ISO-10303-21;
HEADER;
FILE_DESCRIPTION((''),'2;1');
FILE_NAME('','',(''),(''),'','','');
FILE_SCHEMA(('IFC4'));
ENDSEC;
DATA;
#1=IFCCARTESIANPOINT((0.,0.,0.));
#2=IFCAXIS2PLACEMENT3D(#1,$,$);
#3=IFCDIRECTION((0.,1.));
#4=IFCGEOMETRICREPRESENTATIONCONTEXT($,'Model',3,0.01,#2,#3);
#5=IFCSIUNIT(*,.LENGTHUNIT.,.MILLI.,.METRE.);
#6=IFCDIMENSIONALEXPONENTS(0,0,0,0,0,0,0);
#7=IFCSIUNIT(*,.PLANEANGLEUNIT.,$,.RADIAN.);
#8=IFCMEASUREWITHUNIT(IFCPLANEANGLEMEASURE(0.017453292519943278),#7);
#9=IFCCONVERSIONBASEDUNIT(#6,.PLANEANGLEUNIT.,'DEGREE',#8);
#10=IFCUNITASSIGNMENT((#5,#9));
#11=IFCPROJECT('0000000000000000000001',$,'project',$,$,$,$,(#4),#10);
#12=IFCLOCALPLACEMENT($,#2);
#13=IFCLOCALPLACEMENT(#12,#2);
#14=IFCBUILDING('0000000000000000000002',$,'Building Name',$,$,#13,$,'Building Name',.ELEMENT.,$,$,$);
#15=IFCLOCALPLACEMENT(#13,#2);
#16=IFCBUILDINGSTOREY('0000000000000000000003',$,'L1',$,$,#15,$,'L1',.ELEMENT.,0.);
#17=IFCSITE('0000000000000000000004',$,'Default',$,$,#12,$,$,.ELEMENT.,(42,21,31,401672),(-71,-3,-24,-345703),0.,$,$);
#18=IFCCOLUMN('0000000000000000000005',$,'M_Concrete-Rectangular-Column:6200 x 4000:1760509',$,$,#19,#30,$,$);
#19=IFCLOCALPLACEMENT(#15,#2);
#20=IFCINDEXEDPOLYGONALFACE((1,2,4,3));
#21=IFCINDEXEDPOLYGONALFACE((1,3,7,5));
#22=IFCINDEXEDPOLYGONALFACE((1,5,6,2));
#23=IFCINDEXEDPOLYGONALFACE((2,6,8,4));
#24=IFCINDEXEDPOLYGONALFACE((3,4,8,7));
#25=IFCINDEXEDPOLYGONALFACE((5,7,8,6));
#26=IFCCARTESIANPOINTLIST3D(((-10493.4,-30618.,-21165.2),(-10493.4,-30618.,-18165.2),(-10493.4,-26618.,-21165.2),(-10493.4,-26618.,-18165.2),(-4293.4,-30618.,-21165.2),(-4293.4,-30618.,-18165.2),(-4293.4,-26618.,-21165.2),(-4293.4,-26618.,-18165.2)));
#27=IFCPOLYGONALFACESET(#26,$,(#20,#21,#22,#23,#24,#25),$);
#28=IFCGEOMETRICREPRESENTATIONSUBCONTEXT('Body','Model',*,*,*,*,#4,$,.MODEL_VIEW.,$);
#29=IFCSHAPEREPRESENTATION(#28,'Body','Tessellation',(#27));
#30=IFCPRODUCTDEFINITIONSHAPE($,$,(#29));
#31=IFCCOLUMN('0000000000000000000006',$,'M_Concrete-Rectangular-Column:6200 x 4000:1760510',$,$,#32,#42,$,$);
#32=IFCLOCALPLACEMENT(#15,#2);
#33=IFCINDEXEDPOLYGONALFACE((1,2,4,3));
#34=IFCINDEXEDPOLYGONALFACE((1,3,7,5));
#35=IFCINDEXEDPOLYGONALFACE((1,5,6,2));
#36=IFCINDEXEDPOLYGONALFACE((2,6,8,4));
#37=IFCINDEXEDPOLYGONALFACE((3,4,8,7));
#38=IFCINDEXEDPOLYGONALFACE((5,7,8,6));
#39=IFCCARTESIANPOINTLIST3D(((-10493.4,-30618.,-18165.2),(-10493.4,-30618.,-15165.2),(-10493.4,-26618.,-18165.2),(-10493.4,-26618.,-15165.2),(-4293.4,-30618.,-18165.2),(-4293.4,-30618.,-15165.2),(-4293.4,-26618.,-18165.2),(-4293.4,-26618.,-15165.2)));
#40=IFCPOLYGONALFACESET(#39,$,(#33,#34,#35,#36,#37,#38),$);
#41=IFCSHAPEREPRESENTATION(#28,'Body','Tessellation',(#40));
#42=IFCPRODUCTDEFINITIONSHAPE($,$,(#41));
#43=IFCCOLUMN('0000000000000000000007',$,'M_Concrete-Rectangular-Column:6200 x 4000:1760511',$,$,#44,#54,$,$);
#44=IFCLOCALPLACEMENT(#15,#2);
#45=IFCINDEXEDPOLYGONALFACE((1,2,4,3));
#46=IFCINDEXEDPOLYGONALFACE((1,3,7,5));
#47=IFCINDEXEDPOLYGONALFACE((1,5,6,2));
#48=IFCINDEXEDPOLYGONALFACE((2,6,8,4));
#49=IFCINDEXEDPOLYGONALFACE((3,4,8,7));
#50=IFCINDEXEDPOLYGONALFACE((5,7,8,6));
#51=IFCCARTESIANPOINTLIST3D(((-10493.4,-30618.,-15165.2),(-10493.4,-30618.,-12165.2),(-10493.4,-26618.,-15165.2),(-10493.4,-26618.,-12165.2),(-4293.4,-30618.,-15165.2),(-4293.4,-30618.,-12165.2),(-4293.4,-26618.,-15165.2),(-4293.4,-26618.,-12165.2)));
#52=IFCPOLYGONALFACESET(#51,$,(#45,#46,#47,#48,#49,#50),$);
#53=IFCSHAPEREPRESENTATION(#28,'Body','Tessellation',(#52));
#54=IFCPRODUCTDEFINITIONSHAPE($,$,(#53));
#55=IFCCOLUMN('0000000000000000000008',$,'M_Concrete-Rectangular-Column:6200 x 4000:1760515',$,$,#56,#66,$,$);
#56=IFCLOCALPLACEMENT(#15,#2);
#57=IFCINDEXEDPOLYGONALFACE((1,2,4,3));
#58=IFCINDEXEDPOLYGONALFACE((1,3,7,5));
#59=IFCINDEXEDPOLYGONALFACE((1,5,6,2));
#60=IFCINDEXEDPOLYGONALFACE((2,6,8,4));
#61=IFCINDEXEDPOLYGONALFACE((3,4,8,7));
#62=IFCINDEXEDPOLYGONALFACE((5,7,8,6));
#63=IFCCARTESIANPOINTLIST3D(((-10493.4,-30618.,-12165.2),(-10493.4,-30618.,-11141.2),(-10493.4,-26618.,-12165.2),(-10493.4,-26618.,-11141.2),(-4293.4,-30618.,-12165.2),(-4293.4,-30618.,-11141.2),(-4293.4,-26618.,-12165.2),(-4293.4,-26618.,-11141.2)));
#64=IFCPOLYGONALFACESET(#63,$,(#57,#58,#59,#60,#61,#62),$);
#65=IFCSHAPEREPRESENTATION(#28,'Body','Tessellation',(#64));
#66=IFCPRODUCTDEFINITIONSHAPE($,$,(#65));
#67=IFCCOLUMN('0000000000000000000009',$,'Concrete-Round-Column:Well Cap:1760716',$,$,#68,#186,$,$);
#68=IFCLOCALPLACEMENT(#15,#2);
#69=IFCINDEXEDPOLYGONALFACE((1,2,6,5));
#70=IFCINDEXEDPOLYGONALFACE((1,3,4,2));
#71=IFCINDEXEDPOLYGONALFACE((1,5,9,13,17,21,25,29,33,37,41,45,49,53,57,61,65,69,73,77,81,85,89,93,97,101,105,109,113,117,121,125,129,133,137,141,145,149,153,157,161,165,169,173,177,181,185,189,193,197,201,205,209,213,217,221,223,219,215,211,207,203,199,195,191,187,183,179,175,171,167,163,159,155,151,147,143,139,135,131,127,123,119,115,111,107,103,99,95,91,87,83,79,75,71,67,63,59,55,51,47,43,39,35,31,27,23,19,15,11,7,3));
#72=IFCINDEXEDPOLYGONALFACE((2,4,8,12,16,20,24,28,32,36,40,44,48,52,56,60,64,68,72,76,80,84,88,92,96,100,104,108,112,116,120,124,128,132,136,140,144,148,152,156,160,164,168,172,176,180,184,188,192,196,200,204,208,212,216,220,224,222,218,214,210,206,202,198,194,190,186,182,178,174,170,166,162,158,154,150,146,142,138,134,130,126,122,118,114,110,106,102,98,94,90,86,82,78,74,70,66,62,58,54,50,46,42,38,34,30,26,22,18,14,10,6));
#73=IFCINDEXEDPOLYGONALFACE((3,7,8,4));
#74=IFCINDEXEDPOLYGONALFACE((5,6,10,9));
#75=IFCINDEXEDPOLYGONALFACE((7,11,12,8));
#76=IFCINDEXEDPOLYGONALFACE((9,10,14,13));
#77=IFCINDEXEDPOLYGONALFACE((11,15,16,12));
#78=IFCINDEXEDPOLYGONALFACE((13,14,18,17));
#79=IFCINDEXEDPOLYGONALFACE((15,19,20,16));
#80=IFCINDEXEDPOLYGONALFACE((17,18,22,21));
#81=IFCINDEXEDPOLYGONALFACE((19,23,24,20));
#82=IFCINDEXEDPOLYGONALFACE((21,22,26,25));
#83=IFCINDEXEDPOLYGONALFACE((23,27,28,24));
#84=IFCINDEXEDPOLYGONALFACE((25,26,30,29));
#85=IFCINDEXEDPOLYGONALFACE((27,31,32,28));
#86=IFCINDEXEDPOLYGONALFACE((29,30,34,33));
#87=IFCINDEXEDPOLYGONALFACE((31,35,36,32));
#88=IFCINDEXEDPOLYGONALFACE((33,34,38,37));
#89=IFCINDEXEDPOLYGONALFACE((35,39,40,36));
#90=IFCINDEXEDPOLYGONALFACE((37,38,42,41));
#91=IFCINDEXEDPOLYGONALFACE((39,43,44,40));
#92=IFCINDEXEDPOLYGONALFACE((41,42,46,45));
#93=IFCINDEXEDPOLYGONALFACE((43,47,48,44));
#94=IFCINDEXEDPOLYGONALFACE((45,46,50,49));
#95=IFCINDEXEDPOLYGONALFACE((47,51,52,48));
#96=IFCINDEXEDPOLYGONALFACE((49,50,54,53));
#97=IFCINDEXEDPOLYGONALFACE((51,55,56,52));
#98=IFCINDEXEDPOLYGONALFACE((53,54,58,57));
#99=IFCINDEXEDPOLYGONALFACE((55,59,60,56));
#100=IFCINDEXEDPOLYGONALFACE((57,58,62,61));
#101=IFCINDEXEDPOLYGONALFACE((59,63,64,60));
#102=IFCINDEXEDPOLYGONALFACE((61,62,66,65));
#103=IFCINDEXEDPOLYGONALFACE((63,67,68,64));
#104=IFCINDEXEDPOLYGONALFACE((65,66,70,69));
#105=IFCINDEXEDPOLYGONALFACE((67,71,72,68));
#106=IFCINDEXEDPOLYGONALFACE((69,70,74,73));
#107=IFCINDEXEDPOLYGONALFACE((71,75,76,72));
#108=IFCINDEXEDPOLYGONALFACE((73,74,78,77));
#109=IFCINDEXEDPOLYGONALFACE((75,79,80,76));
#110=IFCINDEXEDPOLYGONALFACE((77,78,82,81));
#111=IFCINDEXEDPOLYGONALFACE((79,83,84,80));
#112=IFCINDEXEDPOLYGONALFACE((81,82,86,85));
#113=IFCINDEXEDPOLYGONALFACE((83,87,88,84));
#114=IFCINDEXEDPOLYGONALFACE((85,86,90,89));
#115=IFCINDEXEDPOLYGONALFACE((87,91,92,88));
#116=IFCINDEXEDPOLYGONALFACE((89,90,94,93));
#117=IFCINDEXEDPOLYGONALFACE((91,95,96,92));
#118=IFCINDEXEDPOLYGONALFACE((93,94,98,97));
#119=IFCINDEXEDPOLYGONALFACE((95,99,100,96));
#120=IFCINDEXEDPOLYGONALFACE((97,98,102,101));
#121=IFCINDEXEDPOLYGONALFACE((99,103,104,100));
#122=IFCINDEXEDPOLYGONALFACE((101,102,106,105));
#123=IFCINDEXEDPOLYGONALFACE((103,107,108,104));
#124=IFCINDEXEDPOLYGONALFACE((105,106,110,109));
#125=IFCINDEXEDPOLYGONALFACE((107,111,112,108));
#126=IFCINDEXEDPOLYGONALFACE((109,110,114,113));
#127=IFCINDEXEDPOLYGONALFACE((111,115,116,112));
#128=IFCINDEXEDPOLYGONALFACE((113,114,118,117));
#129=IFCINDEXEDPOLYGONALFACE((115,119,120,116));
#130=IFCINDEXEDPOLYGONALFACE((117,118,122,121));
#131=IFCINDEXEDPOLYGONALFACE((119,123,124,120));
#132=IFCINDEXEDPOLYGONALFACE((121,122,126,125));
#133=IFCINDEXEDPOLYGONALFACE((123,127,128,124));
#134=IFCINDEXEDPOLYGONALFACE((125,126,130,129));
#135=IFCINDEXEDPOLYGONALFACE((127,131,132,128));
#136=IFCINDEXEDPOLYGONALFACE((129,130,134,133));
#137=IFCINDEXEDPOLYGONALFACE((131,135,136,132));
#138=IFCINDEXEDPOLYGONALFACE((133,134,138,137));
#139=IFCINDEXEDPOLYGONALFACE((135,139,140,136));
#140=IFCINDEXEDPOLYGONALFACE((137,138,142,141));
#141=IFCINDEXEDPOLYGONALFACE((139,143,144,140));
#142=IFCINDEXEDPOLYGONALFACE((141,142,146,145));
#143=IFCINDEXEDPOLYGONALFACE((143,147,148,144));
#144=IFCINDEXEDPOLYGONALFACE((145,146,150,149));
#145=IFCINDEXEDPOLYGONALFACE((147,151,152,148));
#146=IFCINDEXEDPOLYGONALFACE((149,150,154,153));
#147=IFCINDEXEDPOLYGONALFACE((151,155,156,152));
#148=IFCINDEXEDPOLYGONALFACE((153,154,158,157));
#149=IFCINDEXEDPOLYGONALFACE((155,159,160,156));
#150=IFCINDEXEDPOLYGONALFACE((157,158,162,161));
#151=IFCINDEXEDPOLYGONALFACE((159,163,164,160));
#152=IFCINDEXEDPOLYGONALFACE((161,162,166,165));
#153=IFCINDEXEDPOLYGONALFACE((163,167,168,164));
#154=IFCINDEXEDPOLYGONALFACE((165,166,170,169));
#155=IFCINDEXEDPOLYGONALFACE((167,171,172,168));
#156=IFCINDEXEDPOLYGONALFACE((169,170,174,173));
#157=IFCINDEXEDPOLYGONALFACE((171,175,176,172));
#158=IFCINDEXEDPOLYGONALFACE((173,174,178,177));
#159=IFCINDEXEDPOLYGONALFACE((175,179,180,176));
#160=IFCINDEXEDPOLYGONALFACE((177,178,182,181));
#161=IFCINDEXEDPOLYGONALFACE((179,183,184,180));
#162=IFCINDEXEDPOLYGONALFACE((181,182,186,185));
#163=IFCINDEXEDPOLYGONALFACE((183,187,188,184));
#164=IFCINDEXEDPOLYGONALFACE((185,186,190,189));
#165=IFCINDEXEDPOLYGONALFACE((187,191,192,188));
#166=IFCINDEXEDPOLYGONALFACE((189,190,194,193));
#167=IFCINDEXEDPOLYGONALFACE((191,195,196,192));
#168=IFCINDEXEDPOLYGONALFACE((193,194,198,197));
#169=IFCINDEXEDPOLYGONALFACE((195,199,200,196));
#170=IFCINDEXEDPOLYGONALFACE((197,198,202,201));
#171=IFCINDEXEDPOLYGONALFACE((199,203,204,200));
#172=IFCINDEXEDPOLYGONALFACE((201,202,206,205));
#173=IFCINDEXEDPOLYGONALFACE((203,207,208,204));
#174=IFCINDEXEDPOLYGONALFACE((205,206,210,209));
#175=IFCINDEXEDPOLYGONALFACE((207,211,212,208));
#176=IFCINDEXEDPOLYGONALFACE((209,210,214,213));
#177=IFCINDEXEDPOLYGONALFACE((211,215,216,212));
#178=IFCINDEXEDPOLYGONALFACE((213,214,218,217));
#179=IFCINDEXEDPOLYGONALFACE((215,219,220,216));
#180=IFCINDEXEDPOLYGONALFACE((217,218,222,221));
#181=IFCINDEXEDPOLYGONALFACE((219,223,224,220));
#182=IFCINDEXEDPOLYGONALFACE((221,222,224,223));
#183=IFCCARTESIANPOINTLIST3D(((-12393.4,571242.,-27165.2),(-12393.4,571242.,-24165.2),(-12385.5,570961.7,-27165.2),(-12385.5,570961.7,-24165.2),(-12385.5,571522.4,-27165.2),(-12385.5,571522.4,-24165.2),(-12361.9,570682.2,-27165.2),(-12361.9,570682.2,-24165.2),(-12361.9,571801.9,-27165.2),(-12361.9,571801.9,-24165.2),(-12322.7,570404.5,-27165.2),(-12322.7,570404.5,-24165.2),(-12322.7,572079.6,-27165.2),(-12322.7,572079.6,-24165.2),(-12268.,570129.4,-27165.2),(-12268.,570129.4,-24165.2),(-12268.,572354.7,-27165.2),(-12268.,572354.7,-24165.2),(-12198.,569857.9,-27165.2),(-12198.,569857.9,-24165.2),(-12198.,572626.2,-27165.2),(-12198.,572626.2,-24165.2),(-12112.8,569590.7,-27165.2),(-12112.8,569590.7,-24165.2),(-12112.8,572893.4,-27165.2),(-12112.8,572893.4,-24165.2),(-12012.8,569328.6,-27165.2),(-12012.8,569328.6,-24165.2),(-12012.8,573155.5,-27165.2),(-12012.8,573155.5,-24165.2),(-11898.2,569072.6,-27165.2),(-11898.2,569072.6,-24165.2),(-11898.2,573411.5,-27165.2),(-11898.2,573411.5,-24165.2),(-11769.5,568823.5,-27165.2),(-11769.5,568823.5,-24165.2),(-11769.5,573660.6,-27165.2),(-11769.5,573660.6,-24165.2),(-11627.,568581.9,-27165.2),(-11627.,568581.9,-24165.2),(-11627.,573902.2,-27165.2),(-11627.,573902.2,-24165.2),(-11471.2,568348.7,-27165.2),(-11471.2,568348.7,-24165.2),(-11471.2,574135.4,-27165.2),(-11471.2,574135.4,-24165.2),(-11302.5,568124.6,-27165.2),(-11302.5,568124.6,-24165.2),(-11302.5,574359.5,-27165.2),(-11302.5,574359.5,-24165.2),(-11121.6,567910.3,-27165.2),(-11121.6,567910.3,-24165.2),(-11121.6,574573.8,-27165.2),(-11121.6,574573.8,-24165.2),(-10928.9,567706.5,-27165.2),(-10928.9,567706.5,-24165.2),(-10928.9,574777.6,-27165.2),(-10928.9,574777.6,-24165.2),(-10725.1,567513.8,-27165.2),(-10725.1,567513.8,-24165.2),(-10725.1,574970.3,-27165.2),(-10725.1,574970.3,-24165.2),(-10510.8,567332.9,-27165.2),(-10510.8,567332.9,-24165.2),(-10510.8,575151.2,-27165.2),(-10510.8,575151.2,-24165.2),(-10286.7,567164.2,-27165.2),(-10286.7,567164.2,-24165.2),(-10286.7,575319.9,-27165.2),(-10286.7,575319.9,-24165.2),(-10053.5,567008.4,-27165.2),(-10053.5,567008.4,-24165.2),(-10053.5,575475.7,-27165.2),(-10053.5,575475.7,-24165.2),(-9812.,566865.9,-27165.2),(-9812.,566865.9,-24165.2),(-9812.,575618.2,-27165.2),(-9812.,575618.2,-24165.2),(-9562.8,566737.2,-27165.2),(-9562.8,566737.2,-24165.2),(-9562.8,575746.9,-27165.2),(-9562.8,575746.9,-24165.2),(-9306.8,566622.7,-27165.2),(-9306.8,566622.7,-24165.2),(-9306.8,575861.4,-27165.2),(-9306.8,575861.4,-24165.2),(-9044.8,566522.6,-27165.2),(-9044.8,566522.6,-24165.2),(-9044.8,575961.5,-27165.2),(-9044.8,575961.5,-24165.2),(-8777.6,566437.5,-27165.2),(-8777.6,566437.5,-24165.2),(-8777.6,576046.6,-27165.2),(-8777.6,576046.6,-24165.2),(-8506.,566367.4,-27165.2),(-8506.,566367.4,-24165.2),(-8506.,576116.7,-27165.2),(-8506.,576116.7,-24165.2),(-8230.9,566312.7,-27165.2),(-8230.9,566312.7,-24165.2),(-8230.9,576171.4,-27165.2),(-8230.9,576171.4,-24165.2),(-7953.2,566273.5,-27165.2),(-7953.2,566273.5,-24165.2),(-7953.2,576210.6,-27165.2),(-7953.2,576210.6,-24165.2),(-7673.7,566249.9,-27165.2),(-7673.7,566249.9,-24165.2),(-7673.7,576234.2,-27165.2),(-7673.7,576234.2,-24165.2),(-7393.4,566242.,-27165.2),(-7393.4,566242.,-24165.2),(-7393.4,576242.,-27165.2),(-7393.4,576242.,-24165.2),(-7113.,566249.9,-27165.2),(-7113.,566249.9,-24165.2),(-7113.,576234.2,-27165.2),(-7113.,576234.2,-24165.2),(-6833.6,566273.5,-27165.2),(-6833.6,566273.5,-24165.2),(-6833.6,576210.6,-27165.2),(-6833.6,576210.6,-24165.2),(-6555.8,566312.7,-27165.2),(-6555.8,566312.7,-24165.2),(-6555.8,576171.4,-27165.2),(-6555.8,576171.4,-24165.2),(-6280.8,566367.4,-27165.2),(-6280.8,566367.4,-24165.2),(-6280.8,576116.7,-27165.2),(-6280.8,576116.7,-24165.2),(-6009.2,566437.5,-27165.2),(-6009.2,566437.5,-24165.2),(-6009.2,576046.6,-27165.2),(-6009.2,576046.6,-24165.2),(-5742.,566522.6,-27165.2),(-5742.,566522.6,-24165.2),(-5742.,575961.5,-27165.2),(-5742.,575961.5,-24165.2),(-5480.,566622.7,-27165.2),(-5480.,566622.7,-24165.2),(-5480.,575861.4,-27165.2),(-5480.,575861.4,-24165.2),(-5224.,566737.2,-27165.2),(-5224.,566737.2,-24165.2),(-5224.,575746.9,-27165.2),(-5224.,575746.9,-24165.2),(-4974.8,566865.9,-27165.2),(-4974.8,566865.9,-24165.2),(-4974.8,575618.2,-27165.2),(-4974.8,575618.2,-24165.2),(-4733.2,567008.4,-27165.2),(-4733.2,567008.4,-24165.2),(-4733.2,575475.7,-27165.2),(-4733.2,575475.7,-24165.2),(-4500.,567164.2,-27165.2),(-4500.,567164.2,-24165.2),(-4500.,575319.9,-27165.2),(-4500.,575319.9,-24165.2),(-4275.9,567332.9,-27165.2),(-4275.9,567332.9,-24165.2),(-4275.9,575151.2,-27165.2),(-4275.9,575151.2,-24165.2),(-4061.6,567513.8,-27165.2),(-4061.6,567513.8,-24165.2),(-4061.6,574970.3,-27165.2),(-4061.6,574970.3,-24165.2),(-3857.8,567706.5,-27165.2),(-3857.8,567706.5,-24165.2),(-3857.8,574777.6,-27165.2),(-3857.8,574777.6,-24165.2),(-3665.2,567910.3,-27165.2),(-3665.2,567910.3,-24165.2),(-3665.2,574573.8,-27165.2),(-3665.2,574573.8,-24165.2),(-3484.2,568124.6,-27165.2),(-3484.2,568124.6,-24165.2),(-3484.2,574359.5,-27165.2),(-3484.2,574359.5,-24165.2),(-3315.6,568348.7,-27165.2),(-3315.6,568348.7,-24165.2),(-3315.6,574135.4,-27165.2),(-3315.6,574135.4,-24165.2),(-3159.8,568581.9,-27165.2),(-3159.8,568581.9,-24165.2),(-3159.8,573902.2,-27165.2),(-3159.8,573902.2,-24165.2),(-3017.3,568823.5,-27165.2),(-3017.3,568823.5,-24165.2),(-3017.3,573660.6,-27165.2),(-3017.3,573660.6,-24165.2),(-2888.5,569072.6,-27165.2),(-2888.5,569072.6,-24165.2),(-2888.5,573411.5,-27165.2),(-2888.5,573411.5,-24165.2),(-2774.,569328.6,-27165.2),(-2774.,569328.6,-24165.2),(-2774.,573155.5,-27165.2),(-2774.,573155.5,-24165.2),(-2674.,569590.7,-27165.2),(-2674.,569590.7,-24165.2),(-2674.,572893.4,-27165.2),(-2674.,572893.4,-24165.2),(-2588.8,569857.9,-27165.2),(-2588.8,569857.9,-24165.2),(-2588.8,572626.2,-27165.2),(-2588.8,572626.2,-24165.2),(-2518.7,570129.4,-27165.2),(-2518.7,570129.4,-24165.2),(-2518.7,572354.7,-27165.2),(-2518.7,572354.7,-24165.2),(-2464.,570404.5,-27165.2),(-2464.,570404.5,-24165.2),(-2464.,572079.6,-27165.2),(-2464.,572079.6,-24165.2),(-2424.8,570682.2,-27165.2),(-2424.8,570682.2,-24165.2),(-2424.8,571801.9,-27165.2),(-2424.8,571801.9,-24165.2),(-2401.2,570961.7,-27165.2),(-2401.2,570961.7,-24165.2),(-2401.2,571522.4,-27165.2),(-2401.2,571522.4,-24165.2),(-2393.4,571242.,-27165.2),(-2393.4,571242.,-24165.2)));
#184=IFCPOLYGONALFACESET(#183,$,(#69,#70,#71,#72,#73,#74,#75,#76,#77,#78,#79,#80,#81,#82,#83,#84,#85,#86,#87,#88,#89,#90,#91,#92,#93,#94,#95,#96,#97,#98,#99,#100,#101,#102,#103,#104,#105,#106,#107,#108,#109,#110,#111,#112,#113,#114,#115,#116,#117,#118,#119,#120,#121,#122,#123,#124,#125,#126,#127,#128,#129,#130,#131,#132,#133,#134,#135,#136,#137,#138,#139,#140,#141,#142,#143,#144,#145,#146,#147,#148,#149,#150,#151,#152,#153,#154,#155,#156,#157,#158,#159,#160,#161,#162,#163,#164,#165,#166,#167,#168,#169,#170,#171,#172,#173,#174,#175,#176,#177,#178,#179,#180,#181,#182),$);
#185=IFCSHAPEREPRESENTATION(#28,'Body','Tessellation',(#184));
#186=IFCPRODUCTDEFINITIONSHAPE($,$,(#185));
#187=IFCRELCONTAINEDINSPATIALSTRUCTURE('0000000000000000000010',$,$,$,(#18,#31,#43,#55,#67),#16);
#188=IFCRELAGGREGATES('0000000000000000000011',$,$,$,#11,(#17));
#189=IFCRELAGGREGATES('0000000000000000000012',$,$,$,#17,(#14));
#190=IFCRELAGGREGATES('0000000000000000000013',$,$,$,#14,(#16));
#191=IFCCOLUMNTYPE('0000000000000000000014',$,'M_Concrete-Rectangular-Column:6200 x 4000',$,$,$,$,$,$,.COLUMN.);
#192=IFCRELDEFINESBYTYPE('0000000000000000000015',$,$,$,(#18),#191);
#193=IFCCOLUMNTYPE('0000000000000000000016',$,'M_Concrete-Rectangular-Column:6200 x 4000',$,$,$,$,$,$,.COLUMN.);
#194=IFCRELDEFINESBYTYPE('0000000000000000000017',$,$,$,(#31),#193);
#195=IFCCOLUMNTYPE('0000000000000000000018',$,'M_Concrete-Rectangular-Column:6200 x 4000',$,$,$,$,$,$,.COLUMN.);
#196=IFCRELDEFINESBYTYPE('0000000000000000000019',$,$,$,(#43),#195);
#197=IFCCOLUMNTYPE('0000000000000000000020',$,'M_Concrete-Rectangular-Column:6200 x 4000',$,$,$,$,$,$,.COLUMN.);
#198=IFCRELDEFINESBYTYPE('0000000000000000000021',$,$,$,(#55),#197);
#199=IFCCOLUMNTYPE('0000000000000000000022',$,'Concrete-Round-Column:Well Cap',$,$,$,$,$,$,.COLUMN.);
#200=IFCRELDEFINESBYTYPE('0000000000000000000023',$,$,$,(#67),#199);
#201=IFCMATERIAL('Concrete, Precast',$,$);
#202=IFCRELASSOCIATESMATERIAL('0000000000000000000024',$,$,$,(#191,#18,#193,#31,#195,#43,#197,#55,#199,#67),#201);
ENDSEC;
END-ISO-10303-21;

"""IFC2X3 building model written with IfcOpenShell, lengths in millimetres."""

from ifc_helpers import new_model, entity, si_unit, converted_unit, direction, frame, frame_2d, origin, origin_2d_with_axis, place, context, subcontext, project, spatial, rectangle, circle, extrude, source, transform, mapped, material, type_object, type_shapes, element, save


model = new_model("IFC2X3")

# Units and contexts
model_context = context("Model", 3, precision=0.01, world=origin(), true_north=direction((0.0, 1.0)))
body_context = subcontext(model_context, "Body", "Model", "MODEL_VIEW")
ifc_project = project(units=[si_unit("LENGTHUNIT", "METRE", prefix="MILLI"), converted_unit("PLANEANGLEUNIT", "DEGREE", entity("IfcPlaneAngleMeasure", 0.017453292519943278), si_unit("PLANEANGLEUNIT", "RADIAN"), dimensions=[0, 0, 0, 0, 0, 0, 0])], contexts=[model_context])

# Site, building, storey
site_placement = place(None, origin())
site = spatial("IfcSite", under=ifc_project, at=site_placement, Name="Default", CompositionType="ELEMENT", RefLatitude=(42, 21, 31, 401672), RefLongitude=(-71, -3, -24, -345703), RefElevation=0.0)
building_placement = place(site_placement, origin())
building = spatial("IfcBuilding", under=site, at=building_placement, Name="Building Name", LongName="Building Name", CompositionType="ELEMENT")
storey_placement = place(building_placement, origin())
storey = spatial("IfcBuildingStorey", under=building, at=storey_placement, Name="L1", LongName="L1", CompositionType="ELEMENT", Elevation=0.0)

# Columns
ifc_material_1 = material(Name="Concrete, Precast")
column_type_1 = type_object("IfcColumnType", Name="M_Concrete-Rectangular-Column:6200 x 4000", PredefinedType="COLUMN", material=ifc_material_1)
shared_shape_1 = source(origin(), body_context, "Body", "SweptSolid", [
    extrude(rectangle(XDim=4000.0, YDim=6200.0, at=frame_2d((0.0, 0.0), x_axis=(1.0, 0.0))), frame((-7393.4, -28618.0, -21165.2), z_axis=(0.0, 0.0, 1.0), x_axis=(0.0, -1.0, 0.0)), (0.0, 0.0, 1.0), 3000.0),
])
type_shapes(column_type_1, [shared_shape_1])
column_1_placement = place(storey_placement, origin())
element("IfcColumn", 1, at=column_1_placement, inside=storey, type_object=column_type_1, material=ifc_material_1, Name="M_Concrete-Rectangular-Column:6200 x 4000:1760509", context=body_context, shape_type="MappedRepresentation", body=[
    mapped(shared_shape_1, transform((0.0, 0.0, 0.0), scale=1.0)),
])
column_type_2 = type_object("IfcColumnType", Name="M_Concrete-Rectangular-Column:6200 x 4000", PredefinedType="COLUMN", material=ifc_material_1)
shared_shape_2 = source(origin(), body_context, "Body", "SweptSolid", [
    extrude(rectangle(XDim=4000.0, YDim=6200.0, at=frame_2d((0.0, 0.0), x_axis=(1.0, 0.0))), frame((-7393.4, -28618.0, -18165.2), z_axis=(0.0, 0.0, 1.0), x_axis=(0.0, -1.0, 0.0)), (0.0, 0.0, 1.0), 3000.0),
])
type_shapes(column_type_2, [shared_shape_2])
column_2_placement = place(storey_placement, origin())
element("IfcColumn", 2, at=column_2_placement, inside=storey, type_object=column_type_2, material=ifc_material_1, Name="M_Concrete-Rectangular-Column:6200 x 4000:1760510", context=body_context, shape_type="MappedRepresentation", body=[
    mapped(shared_shape_2, transform((0.0, 0.0, 0.0), scale=1.0)),
])
column_type_3 = type_object("IfcColumnType", Name="M_Concrete-Rectangular-Column:6200 x 4000", PredefinedType="COLUMN", material=ifc_material_1)
shared_shape_3 = source(origin(), body_context, "Body", "SweptSolid", [
    extrude(rectangle(XDim=4000.0, YDim=6200.0, at=frame_2d((0.0, 0.0), x_axis=(1.0, 0.0))), frame((-7393.4, -28618.0, -15165.2), z_axis=(0.0, 0.0, 1.0), x_axis=(0.0, -1.0, 0.0)), (0.0, 0.0, 1.0), 3000.0),
])
type_shapes(column_type_3, [shared_shape_3])
column_3_placement = place(storey_placement, origin())
element("IfcColumn", 3, at=column_3_placement, inside=storey, type_object=column_type_3, material=ifc_material_1, Name="M_Concrete-Rectangular-Column:6200 x 4000:1760511", context=body_context, shape_type="MappedRepresentation", body=[
    mapped(shared_shape_3, transform((0.0, 0.0, 0.0), scale=1.0)),
])
column_type_4 = type_object("IfcColumnType", Name="M_Concrete-Rectangular-Column:6200 x 4000", PredefinedType="COLUMN", material=ifc_material_1)
shared_shape_4 = source(origin(), body_context, "Body", "SweptSolid", [
    extrude(rectangle(XDim=4000.0, YDim=6200.0, at=origin_2d_with_axis()), frame((-7393.4, -28618.0, -12165.2), z_axis=(0.0, 0.0, 1.0), x_axis=(0.0, -1.0, 0.0)), (0.0, 0.0, 1.0), 1024.0),
])
type_shapes(column_type_4, [shared_shape_4])
column_4_placement = place(storey_placement, origin())
element("IfcColumn", 4, at=column_4_placement, inside=storey, type_object=column_type_4, material=ifc_material_1, Name="M_Concrete-Rectangular-Column:6200 x 4000:1760515", context=body_context, shape_type="MappedRepresentation", body=[
    mapped(shared_shape_4, transform((0.0, 0.0, 0.0), scale=1.0)),
])
column_type_5 = type_object("IfcColumnType", Name="Concrete-Round-Column:Well Cap", PredefinedType="COLUMN", material=ifc_material_1)
shared_shape_5 = source(origin(), body_context, "Body", "SweptSolid", [
    extrude(circle(Radius=5000.0, at=origin_2d_with_axis()), frame((-7393.4, 571242.0, -27165.2)), (0.0, 0.0, 1.0), 3000.0),
])
type_shapes(column_type_5, [shared_shape_5])
column_5_placement = place(storey_placement, origin())
element("IfcColumn", 5, at=column_5_placement, inside=storey, type_object=column_type_5, material=ifc_material_1, Name="Concrete-Round-Column:Well Cap:1760716", context=body_context, shape_type="MappedRepresentation", body=[
    mapped(shared_shape_5, transform((0.0, 0.0, 0.0), scale=1.0)),
])

save(model, "model.ifc")
